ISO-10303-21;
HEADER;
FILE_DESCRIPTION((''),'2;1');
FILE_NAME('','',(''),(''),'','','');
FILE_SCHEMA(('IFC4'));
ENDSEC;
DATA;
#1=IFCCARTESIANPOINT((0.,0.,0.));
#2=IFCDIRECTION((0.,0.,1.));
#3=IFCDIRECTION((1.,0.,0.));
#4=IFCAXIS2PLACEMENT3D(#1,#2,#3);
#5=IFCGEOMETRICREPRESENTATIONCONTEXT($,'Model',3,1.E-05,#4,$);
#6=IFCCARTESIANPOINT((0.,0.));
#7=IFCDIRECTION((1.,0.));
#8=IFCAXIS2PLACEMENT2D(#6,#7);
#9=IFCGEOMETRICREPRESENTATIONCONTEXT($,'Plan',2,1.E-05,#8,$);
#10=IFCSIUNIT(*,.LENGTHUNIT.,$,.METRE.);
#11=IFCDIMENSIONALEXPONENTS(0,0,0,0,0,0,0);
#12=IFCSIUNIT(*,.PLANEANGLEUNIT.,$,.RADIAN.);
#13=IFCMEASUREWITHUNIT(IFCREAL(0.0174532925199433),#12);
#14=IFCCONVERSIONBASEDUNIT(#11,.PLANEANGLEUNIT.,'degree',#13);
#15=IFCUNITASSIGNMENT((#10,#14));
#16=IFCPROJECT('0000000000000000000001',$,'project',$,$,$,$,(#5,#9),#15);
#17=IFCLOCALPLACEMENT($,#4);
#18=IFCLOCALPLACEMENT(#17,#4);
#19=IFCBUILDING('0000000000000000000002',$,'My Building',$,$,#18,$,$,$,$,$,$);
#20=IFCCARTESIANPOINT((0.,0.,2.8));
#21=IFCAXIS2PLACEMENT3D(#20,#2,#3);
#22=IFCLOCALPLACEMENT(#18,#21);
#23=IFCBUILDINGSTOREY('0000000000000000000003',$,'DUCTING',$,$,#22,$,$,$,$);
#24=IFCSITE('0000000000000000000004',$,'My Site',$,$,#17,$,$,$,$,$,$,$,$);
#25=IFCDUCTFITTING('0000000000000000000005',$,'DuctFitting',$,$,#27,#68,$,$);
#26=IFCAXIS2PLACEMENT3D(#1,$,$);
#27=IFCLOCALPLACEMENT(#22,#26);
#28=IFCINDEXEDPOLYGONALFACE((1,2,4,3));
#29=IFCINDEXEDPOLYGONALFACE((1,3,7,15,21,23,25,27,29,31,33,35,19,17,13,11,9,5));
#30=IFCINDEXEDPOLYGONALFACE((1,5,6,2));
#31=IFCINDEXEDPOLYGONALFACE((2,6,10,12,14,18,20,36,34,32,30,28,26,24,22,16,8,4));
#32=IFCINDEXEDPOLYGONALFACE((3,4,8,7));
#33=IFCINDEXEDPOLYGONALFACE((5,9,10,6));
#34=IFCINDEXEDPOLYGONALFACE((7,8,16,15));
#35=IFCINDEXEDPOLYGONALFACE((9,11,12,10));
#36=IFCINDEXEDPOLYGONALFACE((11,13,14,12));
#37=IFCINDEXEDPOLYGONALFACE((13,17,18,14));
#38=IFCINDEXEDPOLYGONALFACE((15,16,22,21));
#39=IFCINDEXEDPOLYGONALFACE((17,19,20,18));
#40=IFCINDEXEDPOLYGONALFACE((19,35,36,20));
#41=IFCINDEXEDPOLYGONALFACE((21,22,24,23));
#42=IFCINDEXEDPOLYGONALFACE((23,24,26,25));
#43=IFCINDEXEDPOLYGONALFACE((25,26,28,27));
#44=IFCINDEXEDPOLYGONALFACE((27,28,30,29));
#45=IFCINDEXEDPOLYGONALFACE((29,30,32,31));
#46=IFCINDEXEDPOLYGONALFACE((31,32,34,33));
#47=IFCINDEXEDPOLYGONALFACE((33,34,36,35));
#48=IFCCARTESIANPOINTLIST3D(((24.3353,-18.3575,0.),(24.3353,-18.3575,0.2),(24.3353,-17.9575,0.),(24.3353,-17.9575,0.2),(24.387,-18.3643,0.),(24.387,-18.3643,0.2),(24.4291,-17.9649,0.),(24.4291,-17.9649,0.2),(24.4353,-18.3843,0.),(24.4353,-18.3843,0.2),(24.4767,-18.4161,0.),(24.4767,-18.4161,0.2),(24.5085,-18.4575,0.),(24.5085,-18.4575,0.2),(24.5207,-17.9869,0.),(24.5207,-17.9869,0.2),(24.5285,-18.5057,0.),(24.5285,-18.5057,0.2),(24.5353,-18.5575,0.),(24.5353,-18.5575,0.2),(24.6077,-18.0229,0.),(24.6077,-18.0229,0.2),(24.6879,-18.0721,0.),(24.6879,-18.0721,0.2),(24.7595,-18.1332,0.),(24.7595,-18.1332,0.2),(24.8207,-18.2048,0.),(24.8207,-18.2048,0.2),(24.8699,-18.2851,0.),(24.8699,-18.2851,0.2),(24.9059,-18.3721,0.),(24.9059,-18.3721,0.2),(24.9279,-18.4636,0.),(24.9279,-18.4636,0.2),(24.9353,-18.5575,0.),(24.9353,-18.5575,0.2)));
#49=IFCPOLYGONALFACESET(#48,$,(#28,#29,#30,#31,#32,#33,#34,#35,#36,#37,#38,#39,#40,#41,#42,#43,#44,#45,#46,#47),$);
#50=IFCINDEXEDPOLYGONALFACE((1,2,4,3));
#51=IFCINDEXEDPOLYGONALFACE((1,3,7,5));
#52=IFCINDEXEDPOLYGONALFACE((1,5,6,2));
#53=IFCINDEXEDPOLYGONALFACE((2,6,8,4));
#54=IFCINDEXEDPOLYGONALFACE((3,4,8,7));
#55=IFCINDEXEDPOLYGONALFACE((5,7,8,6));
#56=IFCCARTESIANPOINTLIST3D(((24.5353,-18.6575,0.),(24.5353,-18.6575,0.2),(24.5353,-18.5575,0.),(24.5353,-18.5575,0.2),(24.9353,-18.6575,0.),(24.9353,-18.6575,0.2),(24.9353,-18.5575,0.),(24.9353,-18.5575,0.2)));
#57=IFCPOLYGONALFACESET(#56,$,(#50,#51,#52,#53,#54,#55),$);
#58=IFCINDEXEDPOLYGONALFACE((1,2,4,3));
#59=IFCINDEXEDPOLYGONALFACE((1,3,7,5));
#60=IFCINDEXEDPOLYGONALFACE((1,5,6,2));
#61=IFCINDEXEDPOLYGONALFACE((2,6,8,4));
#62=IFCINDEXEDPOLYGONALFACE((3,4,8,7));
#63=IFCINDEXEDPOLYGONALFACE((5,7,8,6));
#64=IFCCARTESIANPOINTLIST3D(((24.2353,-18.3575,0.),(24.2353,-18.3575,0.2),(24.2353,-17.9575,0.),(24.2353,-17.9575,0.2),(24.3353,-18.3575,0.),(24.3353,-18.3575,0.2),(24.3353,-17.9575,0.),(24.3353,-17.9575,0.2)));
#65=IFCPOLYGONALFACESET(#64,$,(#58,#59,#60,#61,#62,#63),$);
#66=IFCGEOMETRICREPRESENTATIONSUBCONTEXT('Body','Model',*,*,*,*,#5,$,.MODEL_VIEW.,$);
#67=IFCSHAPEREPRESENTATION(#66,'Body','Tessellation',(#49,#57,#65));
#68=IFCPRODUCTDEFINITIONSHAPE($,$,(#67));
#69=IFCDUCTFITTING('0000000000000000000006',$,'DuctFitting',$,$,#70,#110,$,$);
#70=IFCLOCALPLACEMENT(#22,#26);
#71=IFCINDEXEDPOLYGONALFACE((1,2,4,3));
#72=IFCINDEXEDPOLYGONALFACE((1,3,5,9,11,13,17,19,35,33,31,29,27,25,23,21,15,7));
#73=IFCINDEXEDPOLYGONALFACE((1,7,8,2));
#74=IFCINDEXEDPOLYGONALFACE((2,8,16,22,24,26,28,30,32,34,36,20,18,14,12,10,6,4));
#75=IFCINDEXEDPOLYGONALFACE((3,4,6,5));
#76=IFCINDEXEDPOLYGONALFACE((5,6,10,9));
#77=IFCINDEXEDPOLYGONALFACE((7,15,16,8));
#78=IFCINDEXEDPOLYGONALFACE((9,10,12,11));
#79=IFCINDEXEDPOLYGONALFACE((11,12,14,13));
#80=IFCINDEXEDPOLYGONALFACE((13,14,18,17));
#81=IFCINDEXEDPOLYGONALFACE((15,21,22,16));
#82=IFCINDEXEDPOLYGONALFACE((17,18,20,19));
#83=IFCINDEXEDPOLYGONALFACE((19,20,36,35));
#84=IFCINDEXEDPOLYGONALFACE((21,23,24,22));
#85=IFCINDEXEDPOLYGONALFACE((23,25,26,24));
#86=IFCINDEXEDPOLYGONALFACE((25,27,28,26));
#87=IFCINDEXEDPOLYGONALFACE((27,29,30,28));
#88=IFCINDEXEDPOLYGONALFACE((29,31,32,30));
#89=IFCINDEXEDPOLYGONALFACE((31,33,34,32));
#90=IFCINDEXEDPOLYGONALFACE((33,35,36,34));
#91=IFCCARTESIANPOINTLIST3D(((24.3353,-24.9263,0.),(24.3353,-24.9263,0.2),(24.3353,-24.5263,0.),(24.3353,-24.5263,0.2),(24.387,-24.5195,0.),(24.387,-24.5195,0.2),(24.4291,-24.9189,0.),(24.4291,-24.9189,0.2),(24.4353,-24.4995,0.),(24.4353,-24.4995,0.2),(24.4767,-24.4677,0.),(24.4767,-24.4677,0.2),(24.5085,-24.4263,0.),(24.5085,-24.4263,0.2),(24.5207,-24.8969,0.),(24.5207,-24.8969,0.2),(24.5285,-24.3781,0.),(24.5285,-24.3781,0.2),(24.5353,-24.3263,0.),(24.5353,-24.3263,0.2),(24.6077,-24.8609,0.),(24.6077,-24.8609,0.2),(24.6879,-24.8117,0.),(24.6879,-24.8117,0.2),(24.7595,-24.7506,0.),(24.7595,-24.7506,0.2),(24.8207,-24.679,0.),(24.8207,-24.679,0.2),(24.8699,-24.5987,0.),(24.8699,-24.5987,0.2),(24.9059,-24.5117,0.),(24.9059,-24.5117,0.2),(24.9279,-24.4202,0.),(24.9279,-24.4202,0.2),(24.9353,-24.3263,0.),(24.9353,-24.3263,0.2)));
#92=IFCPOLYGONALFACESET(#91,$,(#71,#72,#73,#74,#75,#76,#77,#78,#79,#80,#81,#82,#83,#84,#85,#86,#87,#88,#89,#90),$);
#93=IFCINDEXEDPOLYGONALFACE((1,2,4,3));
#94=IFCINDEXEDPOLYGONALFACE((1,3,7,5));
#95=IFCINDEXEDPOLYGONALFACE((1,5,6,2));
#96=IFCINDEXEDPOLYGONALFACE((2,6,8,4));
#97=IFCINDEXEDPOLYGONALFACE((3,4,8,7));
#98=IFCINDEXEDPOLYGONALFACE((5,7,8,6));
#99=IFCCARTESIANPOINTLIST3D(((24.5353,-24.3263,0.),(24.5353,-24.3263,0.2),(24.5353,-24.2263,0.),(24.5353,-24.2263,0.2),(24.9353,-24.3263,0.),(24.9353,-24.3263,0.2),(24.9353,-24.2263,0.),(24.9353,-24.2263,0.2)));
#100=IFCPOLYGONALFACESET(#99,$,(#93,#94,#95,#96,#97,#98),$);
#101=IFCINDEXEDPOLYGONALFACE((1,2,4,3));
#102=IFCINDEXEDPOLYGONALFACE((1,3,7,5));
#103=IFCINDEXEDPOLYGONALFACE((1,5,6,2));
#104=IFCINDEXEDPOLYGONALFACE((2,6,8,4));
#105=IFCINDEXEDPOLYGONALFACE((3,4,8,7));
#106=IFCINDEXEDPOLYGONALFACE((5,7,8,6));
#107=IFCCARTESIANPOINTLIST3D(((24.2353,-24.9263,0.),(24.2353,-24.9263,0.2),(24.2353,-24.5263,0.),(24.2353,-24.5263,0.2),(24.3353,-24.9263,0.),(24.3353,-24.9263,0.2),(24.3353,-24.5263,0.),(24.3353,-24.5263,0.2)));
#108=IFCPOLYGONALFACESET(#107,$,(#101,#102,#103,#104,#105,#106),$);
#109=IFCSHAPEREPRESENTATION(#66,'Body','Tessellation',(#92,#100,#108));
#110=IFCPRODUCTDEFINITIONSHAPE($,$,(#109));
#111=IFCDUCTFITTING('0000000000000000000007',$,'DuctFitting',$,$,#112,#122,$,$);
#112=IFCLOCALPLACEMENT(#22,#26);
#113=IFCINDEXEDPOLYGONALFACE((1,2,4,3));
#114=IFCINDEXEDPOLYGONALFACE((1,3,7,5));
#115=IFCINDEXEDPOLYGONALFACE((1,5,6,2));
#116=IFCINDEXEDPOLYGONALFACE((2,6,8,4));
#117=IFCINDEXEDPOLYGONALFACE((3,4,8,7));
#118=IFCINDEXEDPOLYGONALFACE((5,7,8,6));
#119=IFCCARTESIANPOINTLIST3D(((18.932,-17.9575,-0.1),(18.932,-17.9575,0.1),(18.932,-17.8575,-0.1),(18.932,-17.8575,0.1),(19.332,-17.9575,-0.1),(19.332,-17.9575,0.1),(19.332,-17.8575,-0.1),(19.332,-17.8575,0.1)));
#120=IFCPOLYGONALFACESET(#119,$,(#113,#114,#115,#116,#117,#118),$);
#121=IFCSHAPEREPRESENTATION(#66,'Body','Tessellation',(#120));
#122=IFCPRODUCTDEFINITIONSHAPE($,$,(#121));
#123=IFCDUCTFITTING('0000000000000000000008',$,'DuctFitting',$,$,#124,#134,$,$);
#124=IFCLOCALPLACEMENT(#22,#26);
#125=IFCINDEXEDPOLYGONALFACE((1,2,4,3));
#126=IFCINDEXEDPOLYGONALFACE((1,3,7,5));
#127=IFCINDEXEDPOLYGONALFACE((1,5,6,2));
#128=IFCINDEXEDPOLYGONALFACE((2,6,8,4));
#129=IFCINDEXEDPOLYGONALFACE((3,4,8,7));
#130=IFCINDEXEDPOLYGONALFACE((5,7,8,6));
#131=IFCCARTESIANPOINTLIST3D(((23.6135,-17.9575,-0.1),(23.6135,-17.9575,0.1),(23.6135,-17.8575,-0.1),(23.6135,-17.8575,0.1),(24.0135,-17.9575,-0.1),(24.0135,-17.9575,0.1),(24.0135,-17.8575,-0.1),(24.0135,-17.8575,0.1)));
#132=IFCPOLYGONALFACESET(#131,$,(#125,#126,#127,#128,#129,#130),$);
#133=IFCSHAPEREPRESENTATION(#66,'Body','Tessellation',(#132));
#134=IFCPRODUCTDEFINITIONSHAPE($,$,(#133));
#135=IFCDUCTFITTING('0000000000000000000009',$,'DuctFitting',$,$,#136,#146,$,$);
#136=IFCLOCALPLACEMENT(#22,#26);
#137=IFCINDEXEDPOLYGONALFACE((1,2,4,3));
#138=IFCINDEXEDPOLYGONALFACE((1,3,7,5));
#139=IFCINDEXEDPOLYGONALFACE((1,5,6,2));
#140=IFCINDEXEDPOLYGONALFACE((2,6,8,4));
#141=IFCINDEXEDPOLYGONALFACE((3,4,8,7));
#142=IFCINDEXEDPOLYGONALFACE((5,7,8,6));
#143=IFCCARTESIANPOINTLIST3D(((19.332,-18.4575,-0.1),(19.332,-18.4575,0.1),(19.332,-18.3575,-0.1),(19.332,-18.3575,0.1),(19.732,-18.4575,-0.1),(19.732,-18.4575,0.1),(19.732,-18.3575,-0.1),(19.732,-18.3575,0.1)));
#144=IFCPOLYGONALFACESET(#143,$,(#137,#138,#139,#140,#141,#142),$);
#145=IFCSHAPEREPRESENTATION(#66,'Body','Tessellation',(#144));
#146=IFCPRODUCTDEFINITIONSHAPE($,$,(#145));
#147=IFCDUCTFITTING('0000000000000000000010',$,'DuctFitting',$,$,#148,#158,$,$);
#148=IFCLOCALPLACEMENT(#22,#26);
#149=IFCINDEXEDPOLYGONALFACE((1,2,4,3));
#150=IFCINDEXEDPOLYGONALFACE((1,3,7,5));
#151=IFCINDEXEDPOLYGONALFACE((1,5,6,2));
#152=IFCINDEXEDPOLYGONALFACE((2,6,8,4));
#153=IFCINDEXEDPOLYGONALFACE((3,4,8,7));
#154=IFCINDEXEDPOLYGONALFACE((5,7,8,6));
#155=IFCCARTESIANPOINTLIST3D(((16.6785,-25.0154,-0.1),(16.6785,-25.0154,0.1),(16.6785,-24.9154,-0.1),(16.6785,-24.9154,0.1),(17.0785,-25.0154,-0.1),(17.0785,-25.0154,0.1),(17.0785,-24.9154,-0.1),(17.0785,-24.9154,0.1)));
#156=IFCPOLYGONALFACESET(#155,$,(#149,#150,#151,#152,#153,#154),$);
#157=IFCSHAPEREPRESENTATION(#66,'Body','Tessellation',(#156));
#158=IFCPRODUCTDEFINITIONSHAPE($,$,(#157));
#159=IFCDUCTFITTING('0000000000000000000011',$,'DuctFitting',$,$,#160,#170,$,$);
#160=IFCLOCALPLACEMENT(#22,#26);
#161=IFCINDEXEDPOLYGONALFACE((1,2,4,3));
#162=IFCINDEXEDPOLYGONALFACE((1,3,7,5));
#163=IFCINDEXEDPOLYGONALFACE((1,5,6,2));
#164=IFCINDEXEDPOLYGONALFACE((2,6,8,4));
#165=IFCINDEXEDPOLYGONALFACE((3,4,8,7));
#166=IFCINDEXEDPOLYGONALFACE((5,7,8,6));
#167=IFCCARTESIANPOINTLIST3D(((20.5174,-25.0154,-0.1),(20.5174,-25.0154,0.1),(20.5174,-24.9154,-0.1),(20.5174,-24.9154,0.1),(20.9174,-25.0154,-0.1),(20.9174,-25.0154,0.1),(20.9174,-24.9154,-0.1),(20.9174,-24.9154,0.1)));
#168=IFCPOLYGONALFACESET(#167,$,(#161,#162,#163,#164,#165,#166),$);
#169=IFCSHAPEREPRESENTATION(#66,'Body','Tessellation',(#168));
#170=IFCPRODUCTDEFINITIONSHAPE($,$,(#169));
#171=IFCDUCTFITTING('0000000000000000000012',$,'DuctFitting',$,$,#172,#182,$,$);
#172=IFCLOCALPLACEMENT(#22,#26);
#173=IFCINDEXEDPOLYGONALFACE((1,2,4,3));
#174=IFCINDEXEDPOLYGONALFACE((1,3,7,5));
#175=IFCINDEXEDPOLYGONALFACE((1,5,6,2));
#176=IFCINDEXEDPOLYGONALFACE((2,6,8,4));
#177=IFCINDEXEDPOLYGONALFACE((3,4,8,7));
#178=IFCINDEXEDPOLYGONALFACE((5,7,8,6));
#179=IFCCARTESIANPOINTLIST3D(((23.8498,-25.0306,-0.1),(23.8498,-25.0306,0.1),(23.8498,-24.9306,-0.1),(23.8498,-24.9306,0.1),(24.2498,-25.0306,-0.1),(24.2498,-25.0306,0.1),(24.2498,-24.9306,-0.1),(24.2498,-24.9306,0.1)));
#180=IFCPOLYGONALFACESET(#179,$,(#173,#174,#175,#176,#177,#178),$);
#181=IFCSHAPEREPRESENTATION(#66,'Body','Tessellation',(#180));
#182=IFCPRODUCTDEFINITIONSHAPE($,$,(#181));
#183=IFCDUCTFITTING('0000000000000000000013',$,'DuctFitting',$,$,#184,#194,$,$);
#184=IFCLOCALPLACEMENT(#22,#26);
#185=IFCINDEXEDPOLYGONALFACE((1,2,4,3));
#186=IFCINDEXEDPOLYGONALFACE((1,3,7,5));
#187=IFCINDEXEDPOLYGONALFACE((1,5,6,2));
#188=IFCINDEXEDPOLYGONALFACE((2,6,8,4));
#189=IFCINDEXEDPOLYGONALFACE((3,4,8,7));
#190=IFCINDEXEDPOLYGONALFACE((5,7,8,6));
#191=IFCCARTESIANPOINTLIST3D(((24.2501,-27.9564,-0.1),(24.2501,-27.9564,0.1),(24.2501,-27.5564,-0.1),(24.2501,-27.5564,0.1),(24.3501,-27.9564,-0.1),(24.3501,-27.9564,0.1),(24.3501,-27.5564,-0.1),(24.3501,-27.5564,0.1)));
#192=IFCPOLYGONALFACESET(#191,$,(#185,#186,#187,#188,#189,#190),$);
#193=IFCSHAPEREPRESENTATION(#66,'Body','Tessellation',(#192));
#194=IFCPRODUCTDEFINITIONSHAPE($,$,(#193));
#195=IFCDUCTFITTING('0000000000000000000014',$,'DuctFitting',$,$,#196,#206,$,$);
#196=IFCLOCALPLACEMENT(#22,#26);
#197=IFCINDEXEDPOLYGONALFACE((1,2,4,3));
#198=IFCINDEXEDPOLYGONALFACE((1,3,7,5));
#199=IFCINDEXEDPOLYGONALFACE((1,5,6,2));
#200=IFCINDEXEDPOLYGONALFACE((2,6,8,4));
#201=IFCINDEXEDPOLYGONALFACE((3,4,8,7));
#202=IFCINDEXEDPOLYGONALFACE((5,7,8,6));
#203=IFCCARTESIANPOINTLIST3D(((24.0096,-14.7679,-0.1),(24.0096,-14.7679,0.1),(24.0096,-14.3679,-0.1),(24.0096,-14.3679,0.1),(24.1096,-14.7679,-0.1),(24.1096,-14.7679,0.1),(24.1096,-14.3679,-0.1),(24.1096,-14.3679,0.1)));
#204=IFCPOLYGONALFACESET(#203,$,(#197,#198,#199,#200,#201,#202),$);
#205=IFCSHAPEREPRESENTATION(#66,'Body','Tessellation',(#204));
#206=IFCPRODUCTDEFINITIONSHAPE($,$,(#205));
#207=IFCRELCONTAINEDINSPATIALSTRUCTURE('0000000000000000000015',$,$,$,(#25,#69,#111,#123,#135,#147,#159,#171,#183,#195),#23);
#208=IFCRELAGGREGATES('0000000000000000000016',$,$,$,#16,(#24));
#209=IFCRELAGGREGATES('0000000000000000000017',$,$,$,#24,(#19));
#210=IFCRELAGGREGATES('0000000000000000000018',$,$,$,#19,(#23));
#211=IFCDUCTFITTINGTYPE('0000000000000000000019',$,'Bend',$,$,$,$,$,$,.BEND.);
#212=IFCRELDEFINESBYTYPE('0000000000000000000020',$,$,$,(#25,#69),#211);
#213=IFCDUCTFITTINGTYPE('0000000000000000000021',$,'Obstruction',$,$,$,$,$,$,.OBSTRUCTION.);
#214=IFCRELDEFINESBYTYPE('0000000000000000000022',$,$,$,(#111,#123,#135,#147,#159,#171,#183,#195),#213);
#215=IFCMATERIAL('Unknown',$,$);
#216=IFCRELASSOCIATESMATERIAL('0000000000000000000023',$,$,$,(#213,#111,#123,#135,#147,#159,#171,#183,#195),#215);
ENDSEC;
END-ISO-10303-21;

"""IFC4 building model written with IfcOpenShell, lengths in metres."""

from ifc_helpers import new_model, entity, si_unit, converted_unit, frame, origin_with_axes, origin_2d_with_axis, place, context, subcontext, project, spatial, line, arc, indexed_curve, rectangle, outline, extrude, source, transform, mapped, material, material_profile, profile_set, profile_usage, type_object, type_shapes, element, save


model = new_model("IFC4")

# Units and contexts
model_context = context("Model", 3, precision=1e-05, world=origin_with_axes())
plan_context = context("Plan", 2, precision=1e-05, world=origin_2d_with_axis())
body_context = subcontext(model_context, "Body", "Model", "MODEL_VIEW")
ifc_project = project(units=[si_unit("LENGTHUNIT", "METRE"), converted_unit("PLANEANGLEUNIT", "degree", entity("IfcReal", 0.0174532925199433), si_unit("PLANEANGLEUNIT", "RADIAN"), dimensions=[0, 0, 0, 0, 0, 0, 0])], contexts=[model_context, plan_context])

# Site, building, storey
site_placement = place(None, origin_with_axes())
site = spatial("IfcSite", under=ifc_project, at=site_placement, Name="My Site")
building_placement = place(site_placement, origin_with_axes())
building = spatial("IfcBuilding", under=site, at=building_placement, Name="My Building")
storey_placement = place(building_placement, frame((0.0, 0.0, 2.8), z_axis=(0.0, 0.0, 1.0), x_axis=(1.0, 0.0, 0.0)))
storey = spatial("IfcBuildingStorey", under=building, at=storey_placement, Name="DUCTING")

# Shared definitions
ifc_material = material(Name="Unknown")

# Duct fittings
duct_fitting_type_1 = type_object("IfcDuctFittingType", Name="Bend", PredefinedType="BEND")
shared_shape = source(origin_with_axes(), body_context, "Body", "SweptSolid", [
    extrude(outline(indexed_curve([(-0.2, 0.0), (-0.2586, -0.1414), (-0.4, -0.2), (-0.4, -0.6), (0.0243, -0.4243), (0.2, 0.0)], segments=[arc(1, 2, 3), line(3, 4), arc(4, 5, 6), line(6, 1)])), frame((0.0, -0.1, -0.1), z_axis=(0.0, -1.0, 0.0), x_axis=(1.0, 0.0, 0.0)), (0.0, 0.0, -1.0), 0.2),
    extrude(rectangle(XDim=0.4, YDim=0.2), origin_with_axes(), (0.0, 0.0, -1.0), 0.1),
    extrude(rectangle(XDim=0.4, YDim=0.2), frame((-0.4, 0.0, -0.5), z_axis=(-1.0, 0.0, 0.0), x_axis=(0.0, 0.0, -1.0)), (0.0, 0.0, 1.0), 0.1),
])
type_shapes(duct_fitting_type_1, [shared_shape])
for number, where, z_axis, x_axis, name in (
    (1, (24.7353, -18.6575, 0.1), (0.0, -1.0, 0.0), (1.0, 0.0, 0.0), "DuctFitting"),
    (2, (24.7353, -24.2263, 0.1), (0.0, 1.0, 0.0), (1.0, 0.0, 0.0), "DuctFitting"),
):
    element("IfcDuctFitting", number, at=place(storey_placement, frame(where, z_axis=z_axis, x_axis=x_axis)), inside=storey, type_object=duct_fitting_type_1, Name=name, context=body_context, shape_type="MappedRepresentation", body=[
        mapped(shared_shape, transform((0.0, 0.0, 0.0), x_axis=(1.0, 0.0, 0.0), y_axis=(0.0, 1.0, 0.0), z_axis=(0.0, 0.0, 1.0), scale=1.0)),
    ])
ifc_material_profile_1 = material_profile(ifc_material, rectangle(XDim=0.4, YDim=0.2))
ifc_profile_set_1 = profile_set([ifc_material_profile_1])
ifc_profile_usage_1 = profile_usage(ifc_profile_set_1, cardinal=5)
duct_fitting_type_2 = type_object("IfcDuctFittingType", Name="Obstruction", PredefinedType="OBSTRUCTION", material=ifc_profile_set_1)
duct_fitting_1_placement = place(storey_placement, frame((19.132, -17.9575, 0.0), z_axis=(0.0, 1.0, 0.0), x_axis=(-1.0, 0.0, 0.0)))
element("IfcDuctFitting", 3, at=duct_fitting_1_placement, inside=storey, type_object=duct_fitting_type_2, material=ifc_profile_usage_1, Name="DuctFitting", context=body_context, shape_type="SweptSolid", body=[
    extrude(rectangle(XDim=0.4, YDim=0.2), origin_with_axes(), (0.0, 0.0, 1.0), 0.1),
])
ifc_profile_usage_2 = profile_usage(ifc_profile_set_1, cardinal=5)
duct_fitting_2_placement = place(storey_placement, frame((23.8135, -17.9575, 0.0), z_axis=(0.0, 1.0, 0.0), x_axis=(-1.0, 0.0, 0.0)))
element("IfcDuctFitting", 4, at=duct_fitting_2_placement, inside=storey, type_object=duct_fitting_type_2, material=ifc_profile_usage_2, Name="DuctFitting", context=body_context, shape_type="SweptSolid", body=[
    extrude(rectangle(XDim=0.4, YDim=0.2), origin_with_axes(), (0.0, 0.0, 1.0), 0.1),
])
ifc_profile_usage_3 = profile_usage(ifc_profile_set_1, cardinal=5)
duct_fitting_3_placement = place(storey_placement, frame((19.532, -18.3575, 0.0), z_axis=(0.0, -1.0, 0.0), x_axis=(1.0, 0.0, 0.0)))
element("IfcDuctFitting", 5, at=duct_fitting_3_placement, inside=storey, type_object=duct_fitting_type_2, material=ifc_profile_usage_3, Name="DuctFitting", context=body_context, shape_type="SweptSolid", body=[
    extrude(rectangle(XDim=0.4, YDim=0.2), origin_with_axes(), (0.0, 0.0, 1.0), 0.1),
])
ifc_profile_usage_4 = profile_usage(ifc_profile_set_1, cardinal=5)
duct_fitting_4_placement = place(storey_placement, frame((16.8785, -24.9154, 0.0), z_axis=(0.0, -1.0, 0.0), x_axis=(1.0, 0.0, 0.0)))
element("IfcDuctFitting", 6, at=duct_fitting_4_placement, inside=storey, type_object=duct_fitting_type_2, material=ifc_profile_usage_4, Name="DuctFitting", context=body_context, shape_type="SweptSolid", body=[
    extrude(rectangle(XDim=0.4, YDim=0.2), origin_with_axes(), (0.0, 0.0, 1.0), 0.1),
])
ifc_profile_usage_5 = profile_usage(ifc_profile_set_1, cardinal=5)
duct_fitting_5_placement = place(storey_placement, frame((20.7174, -24.9154, 0.0), z_axis=(0.0, -1.0, 0.0), x_axis=(1.0, 0.0, 0.0)))
element("IfcDuctFitting", 7, at=duct_fitting_5_placement, inside=storey, type_object=duct_fitting_type_2, material=ifc_profile_usage_5, Name="DuctFitting", context=body_context, shape_type="SweptSolid", body=[
    extrude(rectangle(XDim=0.4, YDim=0.2), origin_with_axes(), (0.0, 0.0, 1.0), 0.1),
])
ifc_profile_usage_6 = profile_usage(ifc_profile_set_1, cardinal=5)
duct_fitting_6_placement = place(storey_placement, frame((24.0498, -24.9306, 0.0), z_axis=(0.0, -1.0, 0.0), x_axis=(1.0, 0.0, 0.0)))
element("IfcDuctFitting", 8, at=duct_fitting_6_placement, inside=storey, type_object=duct_fitting_type_2, material=ifc_profile_usage_6, Name="DuctFitting", context=body_context, shape_type="SweptSolid", body=[
    extrude(rectangle(XDim=0.4, YDim=0.2), origin_with_axes(), (0.0, 0.0, 1.0), 0.1),
])
ifc_profile_usage_7 = profile_usage(ifc_profile_set_1, cardinal=5)
duct_fitting_7_placement = place(storey_placement, frame((24.2501, -27.7564, 0.0), z_axis=(1.0, 0.0, 0.0), x_axis=(0.0, 1.0, 0.0)))
element("IfcDuctFitting", 9, at=duct_fitting_7_placement, inside=storey, type_object=duct_fitting_type_2, material=ifc_profile_usage_7, Name="DuctFitting", context=body_context, shape_type="SweptSolid", body=[
    extrude(rectangle(XDim=0.4, YDim=0.2), origin_with_axes(), (0.0, 0.0, 1.0), 0.1),
])
ifc_profile_usage_8 = profile_usage(ifc_profile_set_1, cardinal=5)
duct_fitting_8_placement = place(storey_placement, frame((24.0096, -14.5679, 0.0), z_axis=(1.0, 0.0, 0.0), x_axis=(0.0, 1.0, 0.0)))
element("IfcDuctFitting", 10, at=duct_fitting_8_placement, inside=storey, type_object=duct_fitting_type_2, material=ifc_profile_usage_8, Name="DuctFitting", context=body_context, shape_type="SweptSolid", body=[
    extrude(rectangle(XDim=0.4, YDim=0.2), origin_with_axes(), (0.0, 0.0, 1.0), 0.1),
])

save(model, "model.ifc")
